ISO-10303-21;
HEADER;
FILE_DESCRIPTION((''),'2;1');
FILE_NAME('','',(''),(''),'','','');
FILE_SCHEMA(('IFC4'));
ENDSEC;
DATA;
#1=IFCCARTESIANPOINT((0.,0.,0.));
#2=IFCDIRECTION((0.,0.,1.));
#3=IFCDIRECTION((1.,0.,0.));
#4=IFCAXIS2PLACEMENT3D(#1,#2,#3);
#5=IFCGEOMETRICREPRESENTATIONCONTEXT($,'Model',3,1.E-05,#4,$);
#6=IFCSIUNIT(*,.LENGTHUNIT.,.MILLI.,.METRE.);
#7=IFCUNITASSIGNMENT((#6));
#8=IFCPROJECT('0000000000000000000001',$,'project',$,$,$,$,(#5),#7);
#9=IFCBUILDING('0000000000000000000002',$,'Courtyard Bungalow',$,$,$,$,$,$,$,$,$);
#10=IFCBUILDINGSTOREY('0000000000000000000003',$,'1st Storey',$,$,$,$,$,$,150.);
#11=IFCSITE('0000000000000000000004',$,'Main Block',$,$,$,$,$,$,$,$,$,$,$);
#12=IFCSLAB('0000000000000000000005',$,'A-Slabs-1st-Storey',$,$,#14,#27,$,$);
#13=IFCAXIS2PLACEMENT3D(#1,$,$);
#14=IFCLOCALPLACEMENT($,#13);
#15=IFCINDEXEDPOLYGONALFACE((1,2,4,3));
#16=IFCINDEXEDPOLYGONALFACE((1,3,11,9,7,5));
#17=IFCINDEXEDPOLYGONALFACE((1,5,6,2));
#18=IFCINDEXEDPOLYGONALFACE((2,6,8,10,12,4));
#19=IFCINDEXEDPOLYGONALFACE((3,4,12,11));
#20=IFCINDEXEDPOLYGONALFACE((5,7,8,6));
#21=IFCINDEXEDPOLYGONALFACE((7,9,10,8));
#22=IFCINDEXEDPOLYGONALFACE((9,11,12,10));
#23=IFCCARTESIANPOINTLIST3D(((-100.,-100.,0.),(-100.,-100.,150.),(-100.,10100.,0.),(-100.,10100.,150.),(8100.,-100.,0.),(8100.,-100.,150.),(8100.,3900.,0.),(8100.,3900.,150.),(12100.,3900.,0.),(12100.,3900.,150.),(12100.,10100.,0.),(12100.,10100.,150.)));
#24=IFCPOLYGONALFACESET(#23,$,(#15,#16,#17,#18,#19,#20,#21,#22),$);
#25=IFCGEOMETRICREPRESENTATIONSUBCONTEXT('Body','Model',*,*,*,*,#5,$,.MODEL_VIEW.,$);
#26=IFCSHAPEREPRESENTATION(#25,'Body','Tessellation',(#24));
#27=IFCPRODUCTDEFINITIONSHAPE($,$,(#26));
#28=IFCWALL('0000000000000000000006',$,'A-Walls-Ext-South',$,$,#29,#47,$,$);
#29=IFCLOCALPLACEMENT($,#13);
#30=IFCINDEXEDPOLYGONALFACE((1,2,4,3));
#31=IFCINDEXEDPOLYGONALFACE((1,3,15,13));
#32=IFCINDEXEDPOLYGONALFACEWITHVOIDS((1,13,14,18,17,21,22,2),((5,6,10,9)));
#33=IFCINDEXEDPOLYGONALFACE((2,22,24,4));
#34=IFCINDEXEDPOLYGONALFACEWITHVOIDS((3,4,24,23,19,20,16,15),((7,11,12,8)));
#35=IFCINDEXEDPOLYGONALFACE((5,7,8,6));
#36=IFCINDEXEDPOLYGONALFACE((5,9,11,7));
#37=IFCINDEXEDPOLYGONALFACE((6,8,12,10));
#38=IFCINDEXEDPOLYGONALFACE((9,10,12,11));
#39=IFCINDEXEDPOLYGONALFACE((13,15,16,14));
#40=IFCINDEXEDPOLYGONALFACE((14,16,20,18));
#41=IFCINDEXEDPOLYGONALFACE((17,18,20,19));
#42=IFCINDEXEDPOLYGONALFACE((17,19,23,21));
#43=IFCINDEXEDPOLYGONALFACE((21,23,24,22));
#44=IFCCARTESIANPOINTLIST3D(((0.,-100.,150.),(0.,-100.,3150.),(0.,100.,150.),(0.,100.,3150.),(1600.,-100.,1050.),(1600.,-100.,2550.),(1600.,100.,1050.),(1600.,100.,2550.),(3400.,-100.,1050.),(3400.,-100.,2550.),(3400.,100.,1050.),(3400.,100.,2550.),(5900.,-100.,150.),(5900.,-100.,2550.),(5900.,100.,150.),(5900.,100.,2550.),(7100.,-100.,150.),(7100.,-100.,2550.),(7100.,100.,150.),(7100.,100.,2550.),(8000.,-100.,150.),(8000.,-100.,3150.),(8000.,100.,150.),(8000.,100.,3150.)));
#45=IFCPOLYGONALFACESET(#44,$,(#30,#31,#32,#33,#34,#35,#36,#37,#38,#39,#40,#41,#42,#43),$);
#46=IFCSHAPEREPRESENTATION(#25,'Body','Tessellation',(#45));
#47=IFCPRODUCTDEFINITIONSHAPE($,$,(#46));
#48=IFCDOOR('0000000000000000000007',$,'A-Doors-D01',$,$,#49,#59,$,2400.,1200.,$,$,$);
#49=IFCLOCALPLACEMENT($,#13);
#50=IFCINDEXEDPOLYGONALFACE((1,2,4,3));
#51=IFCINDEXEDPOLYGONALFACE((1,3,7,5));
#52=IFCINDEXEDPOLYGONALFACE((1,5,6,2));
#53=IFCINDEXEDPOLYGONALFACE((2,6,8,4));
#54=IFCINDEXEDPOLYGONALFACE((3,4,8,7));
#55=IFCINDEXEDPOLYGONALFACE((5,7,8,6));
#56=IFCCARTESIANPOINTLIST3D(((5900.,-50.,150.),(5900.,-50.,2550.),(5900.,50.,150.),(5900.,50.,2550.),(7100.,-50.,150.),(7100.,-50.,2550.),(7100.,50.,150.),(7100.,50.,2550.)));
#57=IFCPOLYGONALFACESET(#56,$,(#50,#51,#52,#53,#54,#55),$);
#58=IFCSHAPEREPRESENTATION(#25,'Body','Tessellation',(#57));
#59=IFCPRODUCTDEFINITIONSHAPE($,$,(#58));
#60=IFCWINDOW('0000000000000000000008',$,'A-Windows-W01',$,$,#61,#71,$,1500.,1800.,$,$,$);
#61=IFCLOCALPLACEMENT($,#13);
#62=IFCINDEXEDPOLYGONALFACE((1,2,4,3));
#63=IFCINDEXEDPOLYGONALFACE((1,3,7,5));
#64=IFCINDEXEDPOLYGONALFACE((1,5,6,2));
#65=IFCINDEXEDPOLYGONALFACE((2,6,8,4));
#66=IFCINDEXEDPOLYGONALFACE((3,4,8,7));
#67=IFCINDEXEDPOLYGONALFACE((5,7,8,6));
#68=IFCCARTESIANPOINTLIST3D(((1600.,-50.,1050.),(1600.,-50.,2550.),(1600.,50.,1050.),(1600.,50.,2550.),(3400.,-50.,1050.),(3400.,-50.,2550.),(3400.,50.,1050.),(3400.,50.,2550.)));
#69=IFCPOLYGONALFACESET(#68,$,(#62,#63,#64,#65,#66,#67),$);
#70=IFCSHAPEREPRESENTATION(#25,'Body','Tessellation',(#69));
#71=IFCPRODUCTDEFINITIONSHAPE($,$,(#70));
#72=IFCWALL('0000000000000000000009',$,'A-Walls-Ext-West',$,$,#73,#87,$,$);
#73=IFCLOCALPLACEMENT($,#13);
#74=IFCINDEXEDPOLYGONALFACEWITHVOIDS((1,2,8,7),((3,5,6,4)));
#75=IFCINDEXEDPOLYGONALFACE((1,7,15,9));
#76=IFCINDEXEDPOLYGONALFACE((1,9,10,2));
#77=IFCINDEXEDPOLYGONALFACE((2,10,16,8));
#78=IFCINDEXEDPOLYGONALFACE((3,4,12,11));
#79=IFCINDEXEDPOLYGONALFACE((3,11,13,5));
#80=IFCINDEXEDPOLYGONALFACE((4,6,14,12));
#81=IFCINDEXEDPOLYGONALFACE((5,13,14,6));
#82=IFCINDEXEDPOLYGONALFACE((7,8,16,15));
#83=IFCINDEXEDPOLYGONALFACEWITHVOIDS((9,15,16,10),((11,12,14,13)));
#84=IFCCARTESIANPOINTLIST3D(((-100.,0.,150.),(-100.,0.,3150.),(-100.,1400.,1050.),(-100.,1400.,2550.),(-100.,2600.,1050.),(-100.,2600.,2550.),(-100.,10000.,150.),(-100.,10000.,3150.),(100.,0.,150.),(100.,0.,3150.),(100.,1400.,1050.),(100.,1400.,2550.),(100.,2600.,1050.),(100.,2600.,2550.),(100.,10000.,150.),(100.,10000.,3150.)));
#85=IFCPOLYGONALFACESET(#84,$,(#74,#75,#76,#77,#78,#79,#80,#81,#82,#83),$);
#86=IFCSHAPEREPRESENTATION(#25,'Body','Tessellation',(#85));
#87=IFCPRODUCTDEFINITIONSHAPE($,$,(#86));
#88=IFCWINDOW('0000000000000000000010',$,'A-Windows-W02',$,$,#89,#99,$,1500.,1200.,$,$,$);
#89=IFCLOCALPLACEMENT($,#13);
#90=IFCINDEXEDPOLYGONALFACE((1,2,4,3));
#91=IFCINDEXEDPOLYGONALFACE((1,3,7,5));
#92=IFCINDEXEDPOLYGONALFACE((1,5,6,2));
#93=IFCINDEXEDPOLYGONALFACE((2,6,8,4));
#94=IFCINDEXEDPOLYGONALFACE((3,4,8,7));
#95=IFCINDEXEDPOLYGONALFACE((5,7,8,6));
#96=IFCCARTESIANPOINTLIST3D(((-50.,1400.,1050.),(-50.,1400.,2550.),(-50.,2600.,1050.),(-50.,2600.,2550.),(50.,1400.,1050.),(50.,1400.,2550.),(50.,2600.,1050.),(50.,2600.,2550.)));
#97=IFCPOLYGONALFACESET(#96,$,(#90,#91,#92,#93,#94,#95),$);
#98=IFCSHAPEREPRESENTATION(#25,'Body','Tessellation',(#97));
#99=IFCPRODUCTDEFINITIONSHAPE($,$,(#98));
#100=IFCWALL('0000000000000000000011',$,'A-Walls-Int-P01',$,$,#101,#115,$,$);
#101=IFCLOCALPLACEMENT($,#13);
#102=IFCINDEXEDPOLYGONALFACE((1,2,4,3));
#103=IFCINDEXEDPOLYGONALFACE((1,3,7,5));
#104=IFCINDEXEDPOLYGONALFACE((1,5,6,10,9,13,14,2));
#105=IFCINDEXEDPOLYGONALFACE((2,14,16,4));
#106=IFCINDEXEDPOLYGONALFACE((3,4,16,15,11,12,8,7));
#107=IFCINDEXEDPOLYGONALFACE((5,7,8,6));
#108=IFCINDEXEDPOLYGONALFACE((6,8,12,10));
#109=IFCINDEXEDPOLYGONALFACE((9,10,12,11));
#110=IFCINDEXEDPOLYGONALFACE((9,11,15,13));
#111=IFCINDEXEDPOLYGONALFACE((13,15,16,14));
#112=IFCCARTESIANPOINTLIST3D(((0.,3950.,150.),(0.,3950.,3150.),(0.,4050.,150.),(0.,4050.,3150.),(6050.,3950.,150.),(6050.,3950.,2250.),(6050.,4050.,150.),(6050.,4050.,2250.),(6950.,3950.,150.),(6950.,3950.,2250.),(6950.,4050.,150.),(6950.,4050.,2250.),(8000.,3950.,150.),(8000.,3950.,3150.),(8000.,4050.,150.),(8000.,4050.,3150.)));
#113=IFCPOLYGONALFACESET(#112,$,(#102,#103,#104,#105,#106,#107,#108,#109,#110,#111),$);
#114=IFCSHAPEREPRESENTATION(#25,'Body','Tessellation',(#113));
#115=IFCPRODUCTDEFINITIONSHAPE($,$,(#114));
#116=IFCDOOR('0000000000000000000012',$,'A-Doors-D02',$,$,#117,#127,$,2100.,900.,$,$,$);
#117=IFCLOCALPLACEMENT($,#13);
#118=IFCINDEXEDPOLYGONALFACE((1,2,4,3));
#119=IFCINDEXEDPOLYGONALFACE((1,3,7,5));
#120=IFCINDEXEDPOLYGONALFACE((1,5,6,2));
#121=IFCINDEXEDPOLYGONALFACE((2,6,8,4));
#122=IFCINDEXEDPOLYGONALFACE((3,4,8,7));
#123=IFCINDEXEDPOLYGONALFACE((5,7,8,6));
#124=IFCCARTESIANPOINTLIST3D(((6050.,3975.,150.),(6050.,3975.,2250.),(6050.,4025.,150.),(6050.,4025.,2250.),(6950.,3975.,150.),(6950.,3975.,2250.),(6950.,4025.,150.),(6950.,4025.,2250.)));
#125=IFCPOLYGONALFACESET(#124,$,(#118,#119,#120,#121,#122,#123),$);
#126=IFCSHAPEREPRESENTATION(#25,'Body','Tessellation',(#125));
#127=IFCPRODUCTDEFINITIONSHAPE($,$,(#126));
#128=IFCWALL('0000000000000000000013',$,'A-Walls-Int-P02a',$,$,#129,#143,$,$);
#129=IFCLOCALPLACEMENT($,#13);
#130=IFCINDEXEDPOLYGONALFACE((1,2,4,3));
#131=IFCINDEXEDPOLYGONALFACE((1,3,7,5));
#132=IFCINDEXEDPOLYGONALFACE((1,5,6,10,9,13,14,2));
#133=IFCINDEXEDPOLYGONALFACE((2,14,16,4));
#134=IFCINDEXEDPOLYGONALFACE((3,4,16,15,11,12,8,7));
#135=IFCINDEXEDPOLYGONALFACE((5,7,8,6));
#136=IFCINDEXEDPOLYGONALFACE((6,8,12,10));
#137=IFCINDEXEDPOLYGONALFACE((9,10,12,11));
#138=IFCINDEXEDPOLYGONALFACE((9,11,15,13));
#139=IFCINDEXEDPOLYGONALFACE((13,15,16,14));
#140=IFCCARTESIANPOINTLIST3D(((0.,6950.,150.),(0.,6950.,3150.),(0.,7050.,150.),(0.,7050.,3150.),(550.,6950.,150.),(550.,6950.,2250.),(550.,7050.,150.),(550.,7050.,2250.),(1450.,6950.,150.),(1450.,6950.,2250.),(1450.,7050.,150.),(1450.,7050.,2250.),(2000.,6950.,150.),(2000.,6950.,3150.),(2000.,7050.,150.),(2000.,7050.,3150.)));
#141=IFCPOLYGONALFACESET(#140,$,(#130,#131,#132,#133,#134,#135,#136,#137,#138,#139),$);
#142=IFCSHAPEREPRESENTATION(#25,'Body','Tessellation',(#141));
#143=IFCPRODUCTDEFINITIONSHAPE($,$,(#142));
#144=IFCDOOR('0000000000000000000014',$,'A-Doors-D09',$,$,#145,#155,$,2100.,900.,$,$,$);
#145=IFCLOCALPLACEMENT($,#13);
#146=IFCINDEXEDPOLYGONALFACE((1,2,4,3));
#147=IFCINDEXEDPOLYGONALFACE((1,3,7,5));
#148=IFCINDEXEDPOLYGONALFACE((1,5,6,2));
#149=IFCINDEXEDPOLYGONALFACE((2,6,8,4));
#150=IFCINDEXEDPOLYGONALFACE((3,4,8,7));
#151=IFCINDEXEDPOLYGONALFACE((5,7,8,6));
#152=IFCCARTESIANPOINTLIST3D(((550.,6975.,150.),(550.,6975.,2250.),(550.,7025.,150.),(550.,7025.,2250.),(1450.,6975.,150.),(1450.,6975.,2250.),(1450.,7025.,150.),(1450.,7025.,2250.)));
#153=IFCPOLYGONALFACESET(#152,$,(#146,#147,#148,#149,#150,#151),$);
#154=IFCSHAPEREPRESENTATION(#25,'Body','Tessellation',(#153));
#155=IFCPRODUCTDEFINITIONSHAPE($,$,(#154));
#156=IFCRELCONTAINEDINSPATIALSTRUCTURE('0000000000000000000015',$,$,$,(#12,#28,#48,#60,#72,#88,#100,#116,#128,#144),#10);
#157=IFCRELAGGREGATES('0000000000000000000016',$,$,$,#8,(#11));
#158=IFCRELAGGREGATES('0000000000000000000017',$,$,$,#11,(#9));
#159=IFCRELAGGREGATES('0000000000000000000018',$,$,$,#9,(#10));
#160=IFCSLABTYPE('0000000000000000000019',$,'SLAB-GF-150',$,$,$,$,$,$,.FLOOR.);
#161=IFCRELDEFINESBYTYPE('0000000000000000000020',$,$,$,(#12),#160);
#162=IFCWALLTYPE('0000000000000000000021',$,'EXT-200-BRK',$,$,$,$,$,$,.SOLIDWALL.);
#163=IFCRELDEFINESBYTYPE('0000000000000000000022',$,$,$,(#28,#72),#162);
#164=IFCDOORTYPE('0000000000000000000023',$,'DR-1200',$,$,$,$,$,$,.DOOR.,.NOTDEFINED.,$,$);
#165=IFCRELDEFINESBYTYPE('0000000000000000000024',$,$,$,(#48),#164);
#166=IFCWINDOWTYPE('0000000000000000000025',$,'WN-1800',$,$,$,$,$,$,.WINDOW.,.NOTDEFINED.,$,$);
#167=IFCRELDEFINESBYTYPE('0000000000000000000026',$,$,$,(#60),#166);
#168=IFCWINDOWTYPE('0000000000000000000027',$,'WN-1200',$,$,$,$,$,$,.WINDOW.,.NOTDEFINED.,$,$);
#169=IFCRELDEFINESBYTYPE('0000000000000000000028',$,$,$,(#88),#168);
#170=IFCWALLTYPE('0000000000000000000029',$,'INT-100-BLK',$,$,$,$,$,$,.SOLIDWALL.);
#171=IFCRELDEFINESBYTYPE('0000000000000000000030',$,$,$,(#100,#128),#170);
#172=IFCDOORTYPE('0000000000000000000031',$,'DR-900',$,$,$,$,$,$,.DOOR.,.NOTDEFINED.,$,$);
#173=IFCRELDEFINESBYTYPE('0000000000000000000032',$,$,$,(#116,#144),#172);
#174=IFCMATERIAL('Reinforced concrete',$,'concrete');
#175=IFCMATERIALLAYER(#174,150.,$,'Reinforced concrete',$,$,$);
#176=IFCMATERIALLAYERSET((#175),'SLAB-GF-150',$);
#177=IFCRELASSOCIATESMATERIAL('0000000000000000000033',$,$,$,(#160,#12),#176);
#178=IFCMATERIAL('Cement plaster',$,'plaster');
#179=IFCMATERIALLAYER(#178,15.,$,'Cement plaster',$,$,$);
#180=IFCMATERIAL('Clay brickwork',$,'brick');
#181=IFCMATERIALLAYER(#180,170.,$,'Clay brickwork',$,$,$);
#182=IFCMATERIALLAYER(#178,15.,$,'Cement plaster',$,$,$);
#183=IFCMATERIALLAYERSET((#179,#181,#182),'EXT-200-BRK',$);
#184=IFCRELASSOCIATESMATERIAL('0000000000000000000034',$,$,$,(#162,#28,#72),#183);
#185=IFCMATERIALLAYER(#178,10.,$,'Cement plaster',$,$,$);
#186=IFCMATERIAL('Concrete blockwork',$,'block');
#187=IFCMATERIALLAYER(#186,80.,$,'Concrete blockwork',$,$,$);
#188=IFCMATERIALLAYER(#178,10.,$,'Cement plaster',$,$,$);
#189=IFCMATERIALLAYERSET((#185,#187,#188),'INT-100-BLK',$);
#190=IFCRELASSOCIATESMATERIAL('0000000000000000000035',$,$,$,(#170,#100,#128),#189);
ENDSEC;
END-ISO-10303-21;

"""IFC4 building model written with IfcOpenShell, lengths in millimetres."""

from ifc_helpers import new_model, si_unit, frame, origin_with_axes, place, context, subcontext, project, spatial, indexed_curve, outline, extrude, material, layer, layer_set, layer_usage, type_object, element, fill, save


model = new_model("IFC4")

# Units and contexts
model_context = context("Model", 3, precision=1e-05, world=origin_with_axes())
body_context = subcontext(model_context, "Body", "Model", "MODEL_VIEW")
ifc_project = project(units=[si_unit("LENGTHUNIT", "METRE", prefix="MILLI")], contexts=[model_context])

# Site, building, storey
site = spatial("IfcSite", under=ifc_project, Name="Main Block")
building = spatial("IfcBuilding", under=site, Name="Courtyard Bungalow")
storey = spatial("IfcBuildingStorey", under=building, Name="1st Storey", Elevation=150.0)

# Slab
ifc_material_1 = material(Name="Reinforced concrete", Category="concrete")
ifc_layer_1 = layer(ifc_material_1, 150.0, Name="Reinforced concrete")
ifc_layer_set_1 = layer_set([ifc_layer_1], Name="SLAB-GF-150")
ifc_layer_usage_1 = layer_usage(ifc_layer_set_1, "AXIS3", "POSITIVE", 0.0)
slab_type = type_object("IfcSlabType", Name="SLAB-GF-150", PredefinedType="FLOOR", material=ifc_layer_set_1)
slab_placement = place(None, origin_with_axes())
element("IfcSlab", 1, at=slab_placement, inside=storey, type_object=slab_type, material=ifc_layer_usage_1, Name="A-Slabs-1st-Storey", context=body_context, shape_type="SweptSolid", body=[
    extrude(outline(indexed_curve([(-100.0, -100.0), (8100.0, -100.0), (8100.0, 3900.0), (12100.0, 3900.0), (12100.0, 10100.0), (-100.0, 10100.0)])), None, (0.0, 0.0, 1.0), 150.0),
])

# Wall, openings, door, window
ifc_material_2 = material(Name="Cement plaster", Category="plaster")
ifc_layer_2 = layer(ifc_material_2, 15.0, Name="Cement plaster")
ifc_material_3 = material(Name="Clay brickwork", Category="brick")
ifc_layer_3 = layer(ifc_material_3, 170.0, Name="Clay brickwork")
ifc_layer_4 = layer(ifc_material_2, 15.0, Name="Cement plaster")
ifc_layer_set_2 = layer_set([ifc_layer_2, ifc_layer_3, ifc_layer_4], Name="EXT-200-BRK")
ifc_layer_usage_2 = layer_usage(ifc_layer_set_2, "AXIS2", "POSITIVE", 0.0)
wall_type_1 = type_object("IfcWallType", Name="EXT-200-BRK", PredefinedType="SOLIDWALL", material=ifc_layer_set_2)
wall_1_placement = place(None, frame((0.0, -100.0, 150.0), z_axis=(0.0, 0.0, 1.0), x_axis=(1.0, 0.0, 0.0)))
wall_1 = element("IfcWall", 2, at=wall_1_placement, inside=storey, type_object=wall_type_1, material=ifc_layer_usage_2, Name="A-Walls-Ext-South", context=body_context, shape_type="SweptSolid", body=[
    extrude(outline(indexed_curve([(0.0, 0.0), (0.0, 200.0), (8000.0, 200.0), (8000.0, 0.0), (0.0, 0.0)], self_intersect=False)), origin_with_axes(), (0.0, 0.0, 1.0), 3000.0),
])
opening_1_placement = place(wall_1_placement, frame((6500.0, 100.0, 0.0), z_axis=(0.0, 0.0, 1.0), x_axis=(1.0, 0.0, 0.0)))
opening_1 = element("IfcOpeningElement", 3, at=opening_1_placement, cuts=wall_1, PredefinedType="OPENING", context=body_context, shape_type="SweptSolid", body=[
    extrude(outline(indexed_curve([(-600.0, -150.0), (600.0, -150.0), (600.0, 150.0), (-600.0, 150.0)])), None, (0.0, 0.0, 1.0), 2400.0),
])
opening_2_placement = place(wall_1_placement, frame((2500.0, 100.0, 900.0), z_axis=(0.0, 0.0, 1.0), x_axis=(1.0, 0.0, 0.0)))
opening_2 = element("IfcOpeningElement", 4, at=opening_2_placement, cuts=wall_1, PredefinedType="OPENING", context=body_context, shape_type="SweptSolid", body=[
    extrude(outline(indexed_curve([(-900.0, -150.0), (900.0, -150.0), (900.0, 150.0), (-900.0, 150.0)])), None, (0.0, 0.0, 1.0), 1500.0),
])
door_type_1 = type_object("IfcDoorType", Name="DR-1200", OperationType="NOTDEFINED", PredefinedType="DOOR")
door_1_placement = place(None, frame((6500.0, 0.0, 150.0), z_axis=(0.0, 0.0, 1.0), x_axis=(1.0, 0.0, 0.0)))
door_1 = element("IfcDoor", 5, at=door_1_placement, inside=storey, type_object=door_type_1, Name="A-Doors-D01", OverallHeight=2400.0, OverallWidth=1200.0, context=body_context, shape_type="SweptSolid", body=[
    extrude(outline(indexed_curve([(-600.0, -50.0), (600.0, -50.0), (600.0, 50.0), (-600.0, 50.0)])), None, (0.0, 0.0, 1.0), 2400.0),
])
fill(opening_1, door_1)
window_type_1 = type_object("IfcWindowType", Name="WN-1800", PartitioningType="NOTDEFINED", PredefinedType="WINDOW")
window_1_placement = place(None, frame((2500.0, 0.0, 1050.0), z_axis=(0.0, 0.0, 1.0), x_axis=(1.0, 0.0, 0.0)))
window_1 = element("IfcWindow", 6, at=window_1_placement, inside=storey, type_object=window_type_1, Name="A-Windows-W01", OverallHeight=1500.0, OverallWidth=1800.0, context=body_context, shape_type="SweptSolid", body=[
    extrude(outline(indexed_curve([(-900.0, -50.0), (900.0, -50.0), (900.0, 50.0), (-900.0, 50.0)])), None, (0.0, 0.0, 1.0), 1500.0),
])
fill(opening_2, window_1)

# Wall, opening, window
ifc_layer_usage_3 = layer_usage(ifc_layer_set_2, "AXIS2", "POSITIVE", 0.0)
wall_2_placement = place(None, frame((-100.0, 10000.0, 150.0), z_axis=(0.0, 0.0, 1.0), x_axis=(0.0, -1.0, 0.0)))
wall_2 = element("IfcWall", 7, at=wall_2_placement, inside=storey, type_object=wall_type_1, material=ifc_layer_usage_3, Name="A-Walls-Ext-West", context=body_context, shape_type="SweptSolid", body=[
    extrude(outline(indexed_curve([(0.0, 0.0), (0.0, 200.0), (10000.0, 200.0), (10000.0, 0.0), (0.0, 0.0)], self_intersect=False)), origin_with_axes(), (0.0, 0.0, 1.0), 3000.0),
])
opening_3_placement = place(wall_2_placement, frame((8000.0, 100.0, 900.0), z_axis=(0.0, 0.0, 1.0), x_axis=(1.0, 0.0, 0.0)))
opening_3 = element("IfcOpeningElement", 8, at=opening_3_placement, cuts=wall_2, PredefinedType="OPENING", context=body_context, shape_type="SweptSolid", body=[
    extrude(outline(indexed_curve([(-600.0, -150.0), (600.0, -150.0), (600.0, 150.0), (-600.0, 150.0)])), None, (0.0, 0.0, 1.0), 1500.0),
])
window_type_2 = type_object("IfcWindowType", Name="WN-1200", PartitioningType="NOTDEFINED", PredefinedType="WINDOW")
window_2_placement = place(None, frame((0.0, 2000.0, 1050.0), z_axis=(0.0, 0.0, 1.0), x_axis=(0.0, -1.0, 0.0)))
window_2 = element("IfcWindow", 9, at=window_2_placement, inside=storey, type_object=window_type_2, Name="A-Windows-W02", OverallHeight=1500.0, OverallWidth=1200.0, context=body_context, shape_type="SweptSolid", body=[
    extrude(outline(indexed_curve([(-600.0, -50.0), (600.0, -50.0), (600.0, 50.0), (-600.0, 50.0)])), None, (0.0, 0.0, 1.0), 1500.0),
])
fill(opening_3, window_2)

# Walls, openings, doors
ifc_layer_5 = layer(ifc_material_2, 10.0, Name="Cement plaster")
ifc_material_4 = material(Name="Concrete blockwork", Category="block")
ifc_layer_6 = layer(ifc_material_4, 80.0, Name="Concrete blockwork")
ifc_layer_7 = layer(ifc_material_2, 10.0, Name="Cement plaster")
ifc_layer_set_3 = layer_set([ifc_layer_5, ifc_layer_6, ifc_layer_7], Name="INT-100-BLK")
ifc_layer_usage_4 = layer_usage(ifc_layer_set_3, "AXIS2", "POSITIVE", 0.0)
wall_type_2 = type_object("IfcWallType", Name="INT-100-BLK", PredefinedType="SOLIDWALL", material=ifc_layer_set_3)
wall_3_placement = place(None, frame((0.0, 3950.0, 150.0), z_axis=(0.0, 0.0, 1.0), x_axis=(1.0, 0.0, 0.0)))
wall_3 = element("IfcWall", 10, at=wall_3_placement, inside=storey, type_object=wall_type_2, material=ifc_layer_usage_4, Name="A-Walls-Int-P01", context=body_context, shape_type="SweptSolid", body=[
    extrude(outline(indexed_curve([(0.0, 0.0), (0.0, 100.0), (8000.0, 100.0), (8000.0, 0.0), (0.0, 0.0)], self_intersect=False)), origin_with_axes(), (0.0, 0.0, 1.0), 3000.0),
])
opening_4_placement = place(wall_3_placement, frame((6500.0, 50.0, 0.0), z_axis=(0.0, 0.0, 1.0), x_axis=(1.0, 0.0, 0.0)))
opening_4 = element("IfcOpeningElement", 11, at=opening_4_placement, cuts=wall_3, PredefinedType="OPENING", context=body_context, shape_type="SweptSolid", body=[
    extrude(outline(indexed_curve([(-450.0, -100.0), (450.0, -100.0), (450.0, 100.0), (-450.0, 100.0)])), None, (0.0, 0.0, 1.0), 2100.0),
])
door_type_2 = type_object("IfcDoorType", Name="DR-900", OperationType="NOTDEFINED", PredefinedType="DOOR")
door_2_placement = place(None, frame((6500.0, 4000.0, 150.0), z_axis=(0.0, 0.0, 1.0), x_axis=(1.0, 0.0, 0.0)))
door_2 = element("IfcDoor", 12, at=door_2_placement, inside=storey, type_object=door_type_2, Name="A-Doors-D02", OverallHeight=2100.0, OverallWidth=900.0, context=body_context, shape_type="SweptSolid", body=[
    extrude(outline(indexed_curve([(-450.0, -25.0), (450.0, -25.0), (450.0, 25.0), (-450.0, 25.0)])), None, (0.0, 0.0, 1.0), 2100.0),
])
fill(opening_4, door_2)
ifc_layer_usage_5 = layer_usage(ifc_layer_set_3, "AXIS2", "POSITIVE", 0.0)
wall_4_placement = place(None, frame((0.0, 6950.0, 150.0), z_axis=(0.0, 0.0, 1.0), x_axis=(1.0, 0.0, 0.0)))
wall_4 = element("IfcWall", 13, at=wall_4_placement, inside=storey, type_object=wall_type_2, material=ifc_layer_usage_5, Name="A-Walls-Int-P02a", context=body_context, shape_type="SweptSolid", body=[
    extrude(outline(indexed_curve([(0.0, 0.0), (0.0, 100.0), (2000.0, 100.0), (2000.0, 0.0), (0.0, 0.0)], self_intersect=False)), origin_with_axes(), (0.0, 0.0, 1.0), 3000.0),
])
opening_5_placement = place(wall_4_placement, frame((1000.0, 50.0, 0.0), z_axis=(0.0, 0.0, 1.0), x_axis=(1.0, 0.0, 0.0)))
opening_5 = element("IfcOpeningElement", 14, at=opening_5_placement, cuts=wall_4, PredefinedType="OPENING", context=body_context, shape_type="SweptSolid", body=[
    extrude(outline(indexed_curve([(-450.0, -100.0), (450.0, -100.0), (450.0, 100.0), (-450.0, 100.0)])), None, (0.0, 0.0, 1.0), 2100.0),
])
door_3_placement = place(None, frame((1000.0, 7000.0, 150.0), z_axis=(0.0, 0.0, 1.0), x_axis=(1.0, 0.0, 0.0)))
door_3 = element("IfcDoor", 15, at=door_3_placement, inside=storey, type_object=door_type_2, Name="A-Doors-D09", OverallHeight=2100.0, OverallWidth=900.0, context=body_context, shape_type="SweptSolid", body=[
    extrude(outline(indexed_curve([(-450.0, -25.0), (450.0, -25.0), (450.0, 25.0), (-450.0, 25.0)])), None, (0.0, 0.0, 1.0), 2100.0),
])
fill(opening_5, door_3)

save(model, "model.ifc")
